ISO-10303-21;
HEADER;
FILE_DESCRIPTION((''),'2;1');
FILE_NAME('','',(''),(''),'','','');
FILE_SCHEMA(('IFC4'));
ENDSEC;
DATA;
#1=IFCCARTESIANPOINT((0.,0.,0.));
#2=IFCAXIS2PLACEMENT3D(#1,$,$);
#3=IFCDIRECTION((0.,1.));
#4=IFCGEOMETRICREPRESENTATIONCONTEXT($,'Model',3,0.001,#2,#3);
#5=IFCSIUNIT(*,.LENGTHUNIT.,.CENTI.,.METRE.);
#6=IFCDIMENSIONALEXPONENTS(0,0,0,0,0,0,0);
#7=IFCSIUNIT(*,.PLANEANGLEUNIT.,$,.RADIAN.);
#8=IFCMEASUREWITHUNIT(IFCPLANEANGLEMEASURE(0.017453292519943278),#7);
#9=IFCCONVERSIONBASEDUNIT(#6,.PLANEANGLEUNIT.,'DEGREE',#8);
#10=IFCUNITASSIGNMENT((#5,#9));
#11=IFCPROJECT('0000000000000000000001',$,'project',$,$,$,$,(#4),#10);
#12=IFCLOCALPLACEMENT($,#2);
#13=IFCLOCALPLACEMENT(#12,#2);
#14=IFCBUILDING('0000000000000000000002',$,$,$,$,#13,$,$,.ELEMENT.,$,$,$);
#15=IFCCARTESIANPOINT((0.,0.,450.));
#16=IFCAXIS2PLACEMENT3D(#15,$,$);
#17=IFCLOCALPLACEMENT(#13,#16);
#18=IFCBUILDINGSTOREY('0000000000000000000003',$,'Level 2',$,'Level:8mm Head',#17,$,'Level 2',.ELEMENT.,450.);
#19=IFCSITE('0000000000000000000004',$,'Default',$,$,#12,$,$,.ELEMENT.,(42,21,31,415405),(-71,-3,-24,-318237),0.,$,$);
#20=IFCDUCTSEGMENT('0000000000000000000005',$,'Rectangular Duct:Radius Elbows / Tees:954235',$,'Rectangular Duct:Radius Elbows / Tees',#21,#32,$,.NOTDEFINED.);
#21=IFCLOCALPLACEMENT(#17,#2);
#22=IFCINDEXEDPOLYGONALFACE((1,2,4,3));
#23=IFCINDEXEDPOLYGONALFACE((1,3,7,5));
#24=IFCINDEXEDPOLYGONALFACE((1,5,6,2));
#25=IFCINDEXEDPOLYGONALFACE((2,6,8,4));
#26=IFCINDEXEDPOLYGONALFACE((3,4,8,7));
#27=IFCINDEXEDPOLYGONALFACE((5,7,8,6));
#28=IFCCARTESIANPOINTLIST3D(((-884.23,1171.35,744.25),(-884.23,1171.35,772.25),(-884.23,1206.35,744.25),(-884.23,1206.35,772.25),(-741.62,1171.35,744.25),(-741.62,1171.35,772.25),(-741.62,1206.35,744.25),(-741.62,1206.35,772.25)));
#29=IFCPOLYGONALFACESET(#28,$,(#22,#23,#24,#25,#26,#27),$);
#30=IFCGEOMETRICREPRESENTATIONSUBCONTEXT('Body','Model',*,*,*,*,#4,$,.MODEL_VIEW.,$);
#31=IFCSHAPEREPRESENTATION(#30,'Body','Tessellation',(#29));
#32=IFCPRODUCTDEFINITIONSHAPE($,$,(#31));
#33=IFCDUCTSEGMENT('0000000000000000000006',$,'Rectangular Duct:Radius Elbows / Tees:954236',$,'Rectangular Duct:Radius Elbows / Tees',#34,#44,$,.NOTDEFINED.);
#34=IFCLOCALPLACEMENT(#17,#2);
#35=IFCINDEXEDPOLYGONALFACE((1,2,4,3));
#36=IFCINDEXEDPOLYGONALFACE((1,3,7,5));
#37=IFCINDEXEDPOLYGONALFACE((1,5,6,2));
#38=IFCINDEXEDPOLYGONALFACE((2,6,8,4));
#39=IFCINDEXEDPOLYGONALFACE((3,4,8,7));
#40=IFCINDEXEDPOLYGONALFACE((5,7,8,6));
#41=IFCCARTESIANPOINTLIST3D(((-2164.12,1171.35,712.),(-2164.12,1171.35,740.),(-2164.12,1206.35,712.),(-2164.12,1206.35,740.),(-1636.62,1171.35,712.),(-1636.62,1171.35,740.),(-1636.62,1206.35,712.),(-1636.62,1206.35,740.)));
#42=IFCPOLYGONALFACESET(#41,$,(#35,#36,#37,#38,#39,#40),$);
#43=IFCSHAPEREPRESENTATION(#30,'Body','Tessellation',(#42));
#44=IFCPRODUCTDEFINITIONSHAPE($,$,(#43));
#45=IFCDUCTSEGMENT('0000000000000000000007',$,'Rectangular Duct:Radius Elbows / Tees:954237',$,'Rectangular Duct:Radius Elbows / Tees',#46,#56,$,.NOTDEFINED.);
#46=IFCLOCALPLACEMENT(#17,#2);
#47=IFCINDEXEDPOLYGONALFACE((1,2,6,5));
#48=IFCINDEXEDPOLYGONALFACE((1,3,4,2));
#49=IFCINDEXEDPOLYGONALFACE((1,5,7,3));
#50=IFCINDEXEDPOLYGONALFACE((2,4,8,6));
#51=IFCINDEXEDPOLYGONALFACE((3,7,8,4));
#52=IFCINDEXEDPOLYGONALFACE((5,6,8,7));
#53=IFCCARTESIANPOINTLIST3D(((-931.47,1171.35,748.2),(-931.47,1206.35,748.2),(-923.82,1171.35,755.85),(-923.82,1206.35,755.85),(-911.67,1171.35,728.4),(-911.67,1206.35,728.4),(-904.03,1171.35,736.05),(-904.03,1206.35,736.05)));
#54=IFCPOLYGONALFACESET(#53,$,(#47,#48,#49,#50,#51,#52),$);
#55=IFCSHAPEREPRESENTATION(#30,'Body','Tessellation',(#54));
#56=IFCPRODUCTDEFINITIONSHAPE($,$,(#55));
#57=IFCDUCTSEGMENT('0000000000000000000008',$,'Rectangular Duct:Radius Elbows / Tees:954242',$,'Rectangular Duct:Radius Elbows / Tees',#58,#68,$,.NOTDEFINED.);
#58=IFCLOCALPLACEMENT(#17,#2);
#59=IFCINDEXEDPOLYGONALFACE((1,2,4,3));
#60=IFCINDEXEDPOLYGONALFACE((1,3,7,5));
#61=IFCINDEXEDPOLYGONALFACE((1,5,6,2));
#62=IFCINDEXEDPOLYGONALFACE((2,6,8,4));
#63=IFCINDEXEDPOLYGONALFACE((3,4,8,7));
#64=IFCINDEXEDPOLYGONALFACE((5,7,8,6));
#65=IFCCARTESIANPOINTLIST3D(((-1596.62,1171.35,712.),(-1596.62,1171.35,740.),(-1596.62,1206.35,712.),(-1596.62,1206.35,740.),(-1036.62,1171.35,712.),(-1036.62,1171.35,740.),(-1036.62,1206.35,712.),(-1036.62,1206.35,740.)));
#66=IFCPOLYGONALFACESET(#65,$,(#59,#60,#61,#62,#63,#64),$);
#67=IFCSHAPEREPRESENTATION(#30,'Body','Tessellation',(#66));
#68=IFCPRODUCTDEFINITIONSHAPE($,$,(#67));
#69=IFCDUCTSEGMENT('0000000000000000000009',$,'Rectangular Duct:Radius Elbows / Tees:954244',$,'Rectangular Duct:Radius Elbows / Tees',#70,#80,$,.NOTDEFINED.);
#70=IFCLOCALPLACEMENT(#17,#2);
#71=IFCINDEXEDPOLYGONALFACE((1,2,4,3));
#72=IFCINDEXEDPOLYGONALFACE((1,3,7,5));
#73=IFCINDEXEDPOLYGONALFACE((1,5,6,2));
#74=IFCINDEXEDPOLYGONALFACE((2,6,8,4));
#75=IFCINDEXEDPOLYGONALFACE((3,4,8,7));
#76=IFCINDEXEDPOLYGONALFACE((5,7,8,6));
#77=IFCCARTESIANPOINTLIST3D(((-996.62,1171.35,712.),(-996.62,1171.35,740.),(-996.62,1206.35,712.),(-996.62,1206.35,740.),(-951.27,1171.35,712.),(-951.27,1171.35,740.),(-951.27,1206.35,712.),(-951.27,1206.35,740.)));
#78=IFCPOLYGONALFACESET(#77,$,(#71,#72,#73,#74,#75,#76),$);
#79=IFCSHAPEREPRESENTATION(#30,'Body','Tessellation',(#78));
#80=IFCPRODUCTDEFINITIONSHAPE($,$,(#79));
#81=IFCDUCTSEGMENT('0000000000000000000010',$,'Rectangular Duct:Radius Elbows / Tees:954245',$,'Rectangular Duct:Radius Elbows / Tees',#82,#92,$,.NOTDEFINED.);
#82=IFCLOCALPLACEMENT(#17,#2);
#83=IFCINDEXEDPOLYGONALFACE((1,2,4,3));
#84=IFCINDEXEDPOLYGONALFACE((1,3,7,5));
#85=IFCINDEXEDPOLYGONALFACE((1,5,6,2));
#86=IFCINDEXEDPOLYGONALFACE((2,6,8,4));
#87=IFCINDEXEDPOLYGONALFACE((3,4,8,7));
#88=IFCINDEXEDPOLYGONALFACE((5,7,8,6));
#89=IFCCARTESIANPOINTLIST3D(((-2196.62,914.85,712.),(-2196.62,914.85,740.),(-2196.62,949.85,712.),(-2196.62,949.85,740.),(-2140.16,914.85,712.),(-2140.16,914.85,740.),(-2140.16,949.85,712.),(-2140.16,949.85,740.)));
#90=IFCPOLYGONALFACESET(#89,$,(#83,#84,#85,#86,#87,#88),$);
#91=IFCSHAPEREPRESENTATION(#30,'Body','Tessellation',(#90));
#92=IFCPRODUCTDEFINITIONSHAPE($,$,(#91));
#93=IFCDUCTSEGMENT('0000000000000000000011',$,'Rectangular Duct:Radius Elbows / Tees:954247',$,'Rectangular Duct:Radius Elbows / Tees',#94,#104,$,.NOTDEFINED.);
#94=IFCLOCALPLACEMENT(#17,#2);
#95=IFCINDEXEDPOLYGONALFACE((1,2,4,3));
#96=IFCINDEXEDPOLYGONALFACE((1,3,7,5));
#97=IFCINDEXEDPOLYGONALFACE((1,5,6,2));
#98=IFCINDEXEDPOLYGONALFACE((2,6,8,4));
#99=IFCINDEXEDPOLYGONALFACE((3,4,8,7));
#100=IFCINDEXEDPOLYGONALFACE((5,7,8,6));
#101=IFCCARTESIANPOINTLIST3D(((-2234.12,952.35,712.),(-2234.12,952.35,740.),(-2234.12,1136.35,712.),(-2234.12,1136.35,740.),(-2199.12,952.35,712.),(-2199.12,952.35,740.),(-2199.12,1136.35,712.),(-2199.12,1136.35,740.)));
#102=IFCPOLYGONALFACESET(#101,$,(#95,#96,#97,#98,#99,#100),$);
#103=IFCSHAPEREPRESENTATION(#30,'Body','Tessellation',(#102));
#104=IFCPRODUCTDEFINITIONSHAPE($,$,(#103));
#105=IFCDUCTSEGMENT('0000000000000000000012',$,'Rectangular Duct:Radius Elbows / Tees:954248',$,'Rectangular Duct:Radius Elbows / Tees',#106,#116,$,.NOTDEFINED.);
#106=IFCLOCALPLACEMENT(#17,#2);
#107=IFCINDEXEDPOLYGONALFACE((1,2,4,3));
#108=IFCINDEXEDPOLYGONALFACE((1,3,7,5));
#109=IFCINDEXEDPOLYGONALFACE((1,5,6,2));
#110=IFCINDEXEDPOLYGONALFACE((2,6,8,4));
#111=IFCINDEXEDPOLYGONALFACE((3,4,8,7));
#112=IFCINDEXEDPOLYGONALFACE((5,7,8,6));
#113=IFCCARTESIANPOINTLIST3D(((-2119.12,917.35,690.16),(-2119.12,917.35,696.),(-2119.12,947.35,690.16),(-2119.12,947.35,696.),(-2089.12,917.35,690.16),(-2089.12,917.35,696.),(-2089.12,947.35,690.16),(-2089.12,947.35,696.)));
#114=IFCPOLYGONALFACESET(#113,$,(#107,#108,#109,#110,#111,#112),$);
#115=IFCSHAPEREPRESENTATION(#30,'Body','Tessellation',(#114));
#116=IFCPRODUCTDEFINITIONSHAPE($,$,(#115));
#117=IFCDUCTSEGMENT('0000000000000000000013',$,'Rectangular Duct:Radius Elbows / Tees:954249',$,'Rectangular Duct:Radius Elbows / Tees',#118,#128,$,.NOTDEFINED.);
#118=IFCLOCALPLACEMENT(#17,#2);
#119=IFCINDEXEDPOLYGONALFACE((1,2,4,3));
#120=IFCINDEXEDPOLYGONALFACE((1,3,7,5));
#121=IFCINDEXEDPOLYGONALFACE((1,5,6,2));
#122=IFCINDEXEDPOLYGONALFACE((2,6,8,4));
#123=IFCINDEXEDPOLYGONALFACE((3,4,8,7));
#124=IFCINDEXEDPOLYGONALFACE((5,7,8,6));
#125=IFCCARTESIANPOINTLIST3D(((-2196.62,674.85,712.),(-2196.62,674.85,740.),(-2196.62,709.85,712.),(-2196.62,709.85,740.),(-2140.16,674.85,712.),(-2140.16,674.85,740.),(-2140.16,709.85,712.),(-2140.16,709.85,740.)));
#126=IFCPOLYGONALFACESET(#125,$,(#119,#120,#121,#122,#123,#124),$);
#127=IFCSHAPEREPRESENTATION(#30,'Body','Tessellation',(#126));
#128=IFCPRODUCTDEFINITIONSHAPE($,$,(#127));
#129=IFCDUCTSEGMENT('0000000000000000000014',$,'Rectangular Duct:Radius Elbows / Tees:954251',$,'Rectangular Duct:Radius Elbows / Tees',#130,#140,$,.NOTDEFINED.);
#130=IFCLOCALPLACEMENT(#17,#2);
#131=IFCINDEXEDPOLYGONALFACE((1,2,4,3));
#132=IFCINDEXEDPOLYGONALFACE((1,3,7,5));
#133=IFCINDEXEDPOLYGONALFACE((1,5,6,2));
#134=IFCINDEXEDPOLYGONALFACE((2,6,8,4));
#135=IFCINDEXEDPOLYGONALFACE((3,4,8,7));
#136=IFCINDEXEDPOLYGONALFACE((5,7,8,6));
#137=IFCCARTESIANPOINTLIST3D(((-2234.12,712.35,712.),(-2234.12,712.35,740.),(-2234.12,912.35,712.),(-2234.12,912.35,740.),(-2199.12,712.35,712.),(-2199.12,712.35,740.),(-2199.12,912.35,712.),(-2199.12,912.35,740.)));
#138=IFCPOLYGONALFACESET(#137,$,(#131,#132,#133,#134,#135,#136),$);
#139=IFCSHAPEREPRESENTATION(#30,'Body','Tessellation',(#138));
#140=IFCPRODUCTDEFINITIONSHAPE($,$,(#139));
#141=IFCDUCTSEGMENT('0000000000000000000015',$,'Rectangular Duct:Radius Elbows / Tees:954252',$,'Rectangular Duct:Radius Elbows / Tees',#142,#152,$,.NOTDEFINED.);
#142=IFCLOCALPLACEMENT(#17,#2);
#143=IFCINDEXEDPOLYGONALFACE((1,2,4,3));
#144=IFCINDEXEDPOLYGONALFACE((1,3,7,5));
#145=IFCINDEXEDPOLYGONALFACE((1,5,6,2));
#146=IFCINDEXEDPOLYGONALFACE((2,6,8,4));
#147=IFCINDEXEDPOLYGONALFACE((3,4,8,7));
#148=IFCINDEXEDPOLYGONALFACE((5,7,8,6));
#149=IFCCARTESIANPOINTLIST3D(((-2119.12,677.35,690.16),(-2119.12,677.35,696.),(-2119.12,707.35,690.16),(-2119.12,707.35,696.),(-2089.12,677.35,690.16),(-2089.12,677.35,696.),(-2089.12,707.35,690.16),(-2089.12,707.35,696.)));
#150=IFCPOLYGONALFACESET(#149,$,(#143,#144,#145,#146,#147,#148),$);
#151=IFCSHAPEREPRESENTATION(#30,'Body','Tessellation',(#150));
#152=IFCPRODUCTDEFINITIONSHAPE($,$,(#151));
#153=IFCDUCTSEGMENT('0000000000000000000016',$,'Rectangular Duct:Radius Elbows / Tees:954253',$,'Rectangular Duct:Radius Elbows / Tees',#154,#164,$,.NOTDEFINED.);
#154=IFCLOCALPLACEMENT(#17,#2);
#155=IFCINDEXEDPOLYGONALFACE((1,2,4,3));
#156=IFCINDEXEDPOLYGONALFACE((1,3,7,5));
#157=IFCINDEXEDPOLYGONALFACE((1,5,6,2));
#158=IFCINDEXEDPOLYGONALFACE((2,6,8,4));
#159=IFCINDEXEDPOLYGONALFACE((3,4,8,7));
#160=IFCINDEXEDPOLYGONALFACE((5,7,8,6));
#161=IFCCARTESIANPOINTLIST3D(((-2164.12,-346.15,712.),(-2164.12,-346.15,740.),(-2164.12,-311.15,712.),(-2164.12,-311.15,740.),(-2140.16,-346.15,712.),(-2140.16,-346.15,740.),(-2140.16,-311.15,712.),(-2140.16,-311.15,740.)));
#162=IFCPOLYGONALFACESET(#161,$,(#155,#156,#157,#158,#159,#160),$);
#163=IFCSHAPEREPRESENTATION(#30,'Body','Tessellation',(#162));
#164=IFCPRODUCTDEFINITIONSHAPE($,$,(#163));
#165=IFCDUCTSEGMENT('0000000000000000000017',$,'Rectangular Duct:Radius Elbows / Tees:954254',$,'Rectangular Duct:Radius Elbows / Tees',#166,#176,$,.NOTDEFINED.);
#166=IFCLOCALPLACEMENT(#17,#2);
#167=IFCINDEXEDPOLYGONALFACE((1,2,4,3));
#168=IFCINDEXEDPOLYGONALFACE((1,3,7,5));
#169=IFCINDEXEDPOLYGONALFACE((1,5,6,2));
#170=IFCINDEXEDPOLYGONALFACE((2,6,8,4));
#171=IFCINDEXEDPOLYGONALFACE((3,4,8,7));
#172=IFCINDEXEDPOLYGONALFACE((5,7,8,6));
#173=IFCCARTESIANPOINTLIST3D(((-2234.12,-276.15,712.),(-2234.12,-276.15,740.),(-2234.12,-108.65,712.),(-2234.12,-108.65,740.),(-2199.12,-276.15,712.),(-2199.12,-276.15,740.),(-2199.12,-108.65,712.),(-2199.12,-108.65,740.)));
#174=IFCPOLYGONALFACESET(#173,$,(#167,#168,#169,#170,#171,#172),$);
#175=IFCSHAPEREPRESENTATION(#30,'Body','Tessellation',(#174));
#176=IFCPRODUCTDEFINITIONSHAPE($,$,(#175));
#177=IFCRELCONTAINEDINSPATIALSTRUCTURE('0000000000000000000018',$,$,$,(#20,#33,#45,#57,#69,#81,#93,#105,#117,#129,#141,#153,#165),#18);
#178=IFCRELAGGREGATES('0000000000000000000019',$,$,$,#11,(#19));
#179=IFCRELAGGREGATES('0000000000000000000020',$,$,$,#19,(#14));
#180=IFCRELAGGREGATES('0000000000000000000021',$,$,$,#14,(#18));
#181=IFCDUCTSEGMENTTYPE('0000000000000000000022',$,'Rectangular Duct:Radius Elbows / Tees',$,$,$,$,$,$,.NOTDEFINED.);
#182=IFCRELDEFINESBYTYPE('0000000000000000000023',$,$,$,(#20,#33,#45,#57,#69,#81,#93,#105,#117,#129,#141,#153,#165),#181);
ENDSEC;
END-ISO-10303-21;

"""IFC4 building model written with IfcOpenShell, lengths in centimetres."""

from ifc_helpers import new_model, entity, si_unit, converted_unit, direction, frame, origin, place, context, subcontext, project, spatial, indexed_curve, outline, extrude, type_object, element, save


model = new_model("IFC4")

# Units and contexts
model_context = context("Model", 3, precision=0.001, world=origin(), true_north=direction((0.0, 1.0)))
body_context = subcontext(model_context, "Body", "Model", "MODEL_VIEW")
ifc_project = project(units=[si_unit("LENGTHUNIT", "METRE", prefix="CENTI"), converted_unit("PLANEANGLEUNIT", "DEGREE", entity("IfcPlaneAngleMeasure", 0.017453292519943278), si_unit("PLANEANGLEUNIT", "RADIAN"), dimensions=[0, 0, 0, 0, 0, 0, 0])], contexts=[model_context])

# Site, building, storey
site_placement = place(None, origin())
site = spatial("IfcSite", under=ifc_project, at=site_placement, Name="Default", CompositionType="ELEMENT", RefLatitude=(42, 21, 31, 415405), RefLongitude=(-71, -3, -24, -318237), RefElevation=0.0)
building_placement = place(site_placement, origin())
building = spatial("IfcBuilding", under=site, at=building_placement, CompositionType="ELEMENT")
storey_placement = place(building_placement, frame((0.0, 0.0, 450.0)))
storey = spatial("IfcBuildingStorey", under=building, at=storey_placement, Name="Level 2", ObjectType="Level:8mm Head", LongName="Level 2", CompositionType="ELEMENT", Elevation=450.0)

# Duct segments
duct_segment_type_1 = type_object("IfcDuctSegmentType", Name="Rectangular Duct:Radius Elbows / Tees", PredefinedType="NOTDEFINED")
duct_segment_1_placement = place(storey_placement, origin())
element("IfcDuctSegment", 1, at=duct_segment_1_placement, inside=storey, type_object=duct_segment_type_1, Name="Rectangular Duct:Radius Elbows / Tees:954235", ObjectType="Rectangular Duct:Radius Elbows / Tees", PredefinedType="NOTDEFINED", context=body_context, shape_type="SweptSolid", body=[
    extrude(outline(indexed_curve([(-71.3, -17.5), (71.3, -17.5), (71.3, 17.5), (-71.3, 17.5), (-71.3, -17.5)], self_intersect=False)), frame((-812.93, 1188.85, 744.25), z_axis=(0.0, 0.0, 1.0), x_axis=(-1.0, 0.0, 0.0)), (0.0, 0.0, 1.0), 28.0),
])
duct_segment_2_placement = place(storey_placement, origin())
element("IfcDuctSegment", 2, at=duct_segment_2_placement, inside=storey, type_object=duct_segment_type_1, Name="Rectangular Duct:Radius Elbows / Tees:954236", ObjectType="Rectangular Duct:Radius Elbows / Tees", PredefinedType="NOTDEFINED", context=body_context, shape_type="SweptSolid", body=[
    extrude(outline(indexed_curve([(-263.75, -17.5), (263.75, -17.5), (263.75, 17.5), (-263.75, 17.5), (-263.75, -17.5)], self_intersect=False)), frame((-1900.37, 1188.85, 712.0), z_axis=(0.0, 0.0, 1.0), x_axis=(-1.0, 0.0, 0.0)), (0.0, 0.0, 1.0), 28.0),
])
duct_segment_3_placement = place(storey_placement, origin())
element("IfcDuctSegment", 3, at=duct_segment_3_placement, inside=storey, type_object=duct_segment_type_1, Name="Rectangular Duct:Radius Elbows / Tees:954237", ObjectType="Rectangular Duct:Radius Elbows / Tees", PredefinedType="NOTDEFINED", context=body_context, shape_type="SweptSolid", body=[
    extrude(outline(indexed_curve([(-5.41, -14.0), (5.41, -14.0), (5.41, 14.0), (-5.41, 14.0), (-5.41, -14.0)], self_intersect=False)), frame((-917.75, 1171.35, 742.12), z_axis=(0.0, 1.0, 0.0), x_axis=(-0.707107, 0.0, -0.707107)), (0.0, 0.0, 1.0), 35.0),
])
duct_segment_4_placement = place(storey_placement, origin())
element("IfcDuctSegment", 4, at=duct_segment_4_placement, inside=storey, type_object=duct_segment_type_1, Name="Rectangular Duct:Radius Elbows / Tees:954242", ObjectType="Rectangular Duct:Radius Elbows / Tees", PredefinedType="NOTDEFINED", context=body_context, shape_type="SweptSolid", body=[
    extrude(outline(indexed_curve([(-280.0, -17.5), (280.0, -17.5), (280.0, 17.5), (-280.0, 17.5), (-280.0, -17.5)], self_intersect=False)), frame((-1316.62, 1188.85, 712.0), z_axis=(0.0, 0.0, 1.0), x_axis=(-1.0, 0.0, 0.0)), (0.0, 0.0, 1.0), 28.0),
])
duct_segment_5_placement = place(storey_placement, origin())
element("IfcDuctSegment", 5, at=duct_segment_5_placement, inside=storey, type_object=duct_segment_type_1, Name="Rectangular Duct:Radius Elbows / Tees:954244", ObjectType="Rectangular Duct:Radius Elbows / Tees", PredefinedType="NOTDEFINED", context=body_context, shape_type="SweptSolid", body=[
    extrude(outline(indexed_curve([(-22.68, -17.5), (22.68, -17.5), (22.68, 17.5), (-22.68, 17.5), (-22.68, -17.5)], self_intersect=False)), frame((-973.95, 1188.85, 712.0), z_axis=(0.0, 0.0, 1.0), x_axis=(-1.0, 0.0, 0.0)), (0.0, 0.0, 1.0), 28.0),
])
duct_segment_6_placement = place(storey_placement, origin())
element("IfcDuctSegment", 6, at=duct_segment_6_placement, inside=storey, type_object=duct_segment_type_1, Name="Rectangular Duct:Radius Elbows / Tees:954245", ObjectType="Rectangular Duct:Radius Elbows / Tees", PredefinedType="NOTDEFINED", context=body_context, shape_type="SweptSolid", body=[
    extrude(outline(indexed_curve([(-28.23, -17.5), (28.23, -17.5), (28.23, 17.5), (-28.23, 17.5), (-28.23, -17.5)], self_intersect=False)), frame((-2168.39, 932.35, 712.0), z_axis=(0.0, 0.0, 1.0), x_axis=(-1.0, 0.0, 0.0)), (0.0, 0.0, 1.0), 28.0),
])
duct_segment_7_placement = place(storey_placement, origin())
element("IfcDuctSegment", 7, at=duct_segment_7_placement, inside=storey, type_object=duct_segment_type_1, Name="Rectangular Duct:Radius Elbows / Tees:954247", ObjectType="Rectangular Duct:Radius Elbows / Tees", PredefinedType="NOTDEFINED", context=body_context, shape_type="SweptSolid", body=[
    extrude(outline(indexed_curve([(-92.0, -17.5), (92.0, -17.5), (92.0, 17.5), (-92.0, 17.5), (-92.0, -17.5)], self_intersect=False)), frame((-2216.62, 1044.35, 712.0), z_axis=(0.0, 0.0, 1.0), x_axis=(0.0, -1.0, 0.0)), (0.0, 0.0, 1.0), 28.0),
])
duct_segment_8_placement = place(storey_placement, origin())
element("IfcDuctSegment", 8, at=duct_segment_8_placement, inside=storey, type_object=duct_segment_type_1, Name="Rectangular Duct:Radius Elbows / Tees:954248", ObjectType="Rectangular Duct:Radius Elbows / Tees", PredefinedType="NOTDEFINED", context=body_context, shape_type="SweptSolid", body=[
    extrude(outline(indexed_curve([(-15.0, -15.0), (15.0, -15.0), (15.0, 15.0), (-15.0, 15.0), (-15.0, -15.0)], self_intersect=False)), frame((-2104.12, 932.35, 690.16)), (0.0, 0.0, 1.0), 5.84),
])
duct_segment_9_placement = place(storey_placement, origin())
element("IfcDuctSegment", 9, at=duct_segment_9_placement, inside=storey, type_object=duct_segment_type_1, Name="Rectangular Duct:Radius Elbows / Tees:954249", ObjectType="Rectangular Duct:Radius Elbows / Tees", PredefinedType="NOTDEFINED", context=body_context, shape_type="SweptSolid", body=[
    extrude(outline(indexed_curve([(-28.23, -17.5), (28.23, -17.5), (28.23, 17.5), (-28.23, 17.5), (-28.23, -17.5)], self_intersect=False)), frame((-2168.39, 692.35, 712.0), z_axis=(0.0, 0.0, 1.0), x_axis=(-1.0, 0.0, 0.0)), (0.0, 0.0, 1.0), 28.0),
])
duct_segment_10_placement = place(storey_placement, origin())
element("IfcDuctSegment", 10, at=duct_segment_10_placement, inside=storey, type_object=duct_segment_type_1, Name="Rectangular Duct:Radius Elbows / Tees:954251", ObjectType="Rectangular Duct:Radius Elbows / Tees", PredefinedType="NOTDEFINED", context=body_context, shape_type="SweptSolid", body=[
    extrude(outline(indexed_curve([(-100.0, -17.5), (100.0, -17.5), (100.0, 17.5), (-100.0, 17.5), (-100.0, -17.5)], self_intersect=False)), frame((-2216.62, 812.35, 712.0), z_axis=(0.0, 0.0, 1.0), x_axis=(0.0, -1.0, 0.0)), (0.0, 0.0, 1.0), 28.0),
])
duct_segment_11_placement = place(storey_placement, origin())
element("IfcDuctSegment", 11, at=duct_segment_11_placement, inside=storey, type_object=duct_segment_type_1, Name="Rectangular Duct:Radius Elbows / Tees:954252", ObjectType="Rectangular Duct:Radius Elbows / Tees", PredefinedType="NOTDEFINED", context=body_context, shape_type="SweptSolid", body=[
    extrude(outline(indexed_curve([(-15.0, -15.0), (15.0, -15.0), (15.0, 15.0), (-15.0, 15.0), (-15.0, -15.0)], self_intersect=False)), frame((-2104.12, 692.35, 690.16)), (0.0, 0.0, 1.0), 5.84),
])
duct_segment_12_placement = place(storey_placement, origin())
element("IfcDuctSegment", 12, at=duct_segment_12_placement, inside=storey, type_object=duct_segment_type_1, Name="Rectangular Duct:Radius Elbows / Tees:954253", ObjectType="Rectangular Duct:Radius Elbows / Tees", PredefinedType="NOTDEFINED", context=body_context, shape_type="SweptSolid", body=[
    extrude(outline(indexed_curve([(-11.98, -17.5), (11.98, -17.5), (11.98, 17.5), (-11.98, 17.5), (-11.98, -17.5)], self_intersect=False)), frame((-2152.14, -328.65, 712.0), z_axis=(0.0, 0.0, 1.0), x_axis=(-1.0, 0.0, 0.0)), (0.0, 0.0, 1.0), 28.0),
])
duct_segment_13_placement = place(storey_placement, origin())
element("IfcDuctSegment", 13, at=duct_segment_13_placement, inside=storey, type_object=duct_segment_type_1, Name="Rectangular Duct:Radius Elbows / Tees:954254", ObjectType="Rectangular Duct:Radius Elbows / Tees", PredefinedType="NOTDEFINED", context=body_context, shape_type="SweptSolid", body=[
    extrude(outline(indexed_curve([(-83.75, -17.5), (83.75, -17.5), (83.75, 17.5), (-83.75, 17.5), (-83.75, -17.5)], self_intersect=False)), frame((-2216.62, -192.4, 712.0), z_axis=(0.0, 0.0, 1.0), x_axis=(0.0, -1.0, 0.0)), (0.0, 0.0, 1.0), 28.0),
])

save(model, "model.ifc")
